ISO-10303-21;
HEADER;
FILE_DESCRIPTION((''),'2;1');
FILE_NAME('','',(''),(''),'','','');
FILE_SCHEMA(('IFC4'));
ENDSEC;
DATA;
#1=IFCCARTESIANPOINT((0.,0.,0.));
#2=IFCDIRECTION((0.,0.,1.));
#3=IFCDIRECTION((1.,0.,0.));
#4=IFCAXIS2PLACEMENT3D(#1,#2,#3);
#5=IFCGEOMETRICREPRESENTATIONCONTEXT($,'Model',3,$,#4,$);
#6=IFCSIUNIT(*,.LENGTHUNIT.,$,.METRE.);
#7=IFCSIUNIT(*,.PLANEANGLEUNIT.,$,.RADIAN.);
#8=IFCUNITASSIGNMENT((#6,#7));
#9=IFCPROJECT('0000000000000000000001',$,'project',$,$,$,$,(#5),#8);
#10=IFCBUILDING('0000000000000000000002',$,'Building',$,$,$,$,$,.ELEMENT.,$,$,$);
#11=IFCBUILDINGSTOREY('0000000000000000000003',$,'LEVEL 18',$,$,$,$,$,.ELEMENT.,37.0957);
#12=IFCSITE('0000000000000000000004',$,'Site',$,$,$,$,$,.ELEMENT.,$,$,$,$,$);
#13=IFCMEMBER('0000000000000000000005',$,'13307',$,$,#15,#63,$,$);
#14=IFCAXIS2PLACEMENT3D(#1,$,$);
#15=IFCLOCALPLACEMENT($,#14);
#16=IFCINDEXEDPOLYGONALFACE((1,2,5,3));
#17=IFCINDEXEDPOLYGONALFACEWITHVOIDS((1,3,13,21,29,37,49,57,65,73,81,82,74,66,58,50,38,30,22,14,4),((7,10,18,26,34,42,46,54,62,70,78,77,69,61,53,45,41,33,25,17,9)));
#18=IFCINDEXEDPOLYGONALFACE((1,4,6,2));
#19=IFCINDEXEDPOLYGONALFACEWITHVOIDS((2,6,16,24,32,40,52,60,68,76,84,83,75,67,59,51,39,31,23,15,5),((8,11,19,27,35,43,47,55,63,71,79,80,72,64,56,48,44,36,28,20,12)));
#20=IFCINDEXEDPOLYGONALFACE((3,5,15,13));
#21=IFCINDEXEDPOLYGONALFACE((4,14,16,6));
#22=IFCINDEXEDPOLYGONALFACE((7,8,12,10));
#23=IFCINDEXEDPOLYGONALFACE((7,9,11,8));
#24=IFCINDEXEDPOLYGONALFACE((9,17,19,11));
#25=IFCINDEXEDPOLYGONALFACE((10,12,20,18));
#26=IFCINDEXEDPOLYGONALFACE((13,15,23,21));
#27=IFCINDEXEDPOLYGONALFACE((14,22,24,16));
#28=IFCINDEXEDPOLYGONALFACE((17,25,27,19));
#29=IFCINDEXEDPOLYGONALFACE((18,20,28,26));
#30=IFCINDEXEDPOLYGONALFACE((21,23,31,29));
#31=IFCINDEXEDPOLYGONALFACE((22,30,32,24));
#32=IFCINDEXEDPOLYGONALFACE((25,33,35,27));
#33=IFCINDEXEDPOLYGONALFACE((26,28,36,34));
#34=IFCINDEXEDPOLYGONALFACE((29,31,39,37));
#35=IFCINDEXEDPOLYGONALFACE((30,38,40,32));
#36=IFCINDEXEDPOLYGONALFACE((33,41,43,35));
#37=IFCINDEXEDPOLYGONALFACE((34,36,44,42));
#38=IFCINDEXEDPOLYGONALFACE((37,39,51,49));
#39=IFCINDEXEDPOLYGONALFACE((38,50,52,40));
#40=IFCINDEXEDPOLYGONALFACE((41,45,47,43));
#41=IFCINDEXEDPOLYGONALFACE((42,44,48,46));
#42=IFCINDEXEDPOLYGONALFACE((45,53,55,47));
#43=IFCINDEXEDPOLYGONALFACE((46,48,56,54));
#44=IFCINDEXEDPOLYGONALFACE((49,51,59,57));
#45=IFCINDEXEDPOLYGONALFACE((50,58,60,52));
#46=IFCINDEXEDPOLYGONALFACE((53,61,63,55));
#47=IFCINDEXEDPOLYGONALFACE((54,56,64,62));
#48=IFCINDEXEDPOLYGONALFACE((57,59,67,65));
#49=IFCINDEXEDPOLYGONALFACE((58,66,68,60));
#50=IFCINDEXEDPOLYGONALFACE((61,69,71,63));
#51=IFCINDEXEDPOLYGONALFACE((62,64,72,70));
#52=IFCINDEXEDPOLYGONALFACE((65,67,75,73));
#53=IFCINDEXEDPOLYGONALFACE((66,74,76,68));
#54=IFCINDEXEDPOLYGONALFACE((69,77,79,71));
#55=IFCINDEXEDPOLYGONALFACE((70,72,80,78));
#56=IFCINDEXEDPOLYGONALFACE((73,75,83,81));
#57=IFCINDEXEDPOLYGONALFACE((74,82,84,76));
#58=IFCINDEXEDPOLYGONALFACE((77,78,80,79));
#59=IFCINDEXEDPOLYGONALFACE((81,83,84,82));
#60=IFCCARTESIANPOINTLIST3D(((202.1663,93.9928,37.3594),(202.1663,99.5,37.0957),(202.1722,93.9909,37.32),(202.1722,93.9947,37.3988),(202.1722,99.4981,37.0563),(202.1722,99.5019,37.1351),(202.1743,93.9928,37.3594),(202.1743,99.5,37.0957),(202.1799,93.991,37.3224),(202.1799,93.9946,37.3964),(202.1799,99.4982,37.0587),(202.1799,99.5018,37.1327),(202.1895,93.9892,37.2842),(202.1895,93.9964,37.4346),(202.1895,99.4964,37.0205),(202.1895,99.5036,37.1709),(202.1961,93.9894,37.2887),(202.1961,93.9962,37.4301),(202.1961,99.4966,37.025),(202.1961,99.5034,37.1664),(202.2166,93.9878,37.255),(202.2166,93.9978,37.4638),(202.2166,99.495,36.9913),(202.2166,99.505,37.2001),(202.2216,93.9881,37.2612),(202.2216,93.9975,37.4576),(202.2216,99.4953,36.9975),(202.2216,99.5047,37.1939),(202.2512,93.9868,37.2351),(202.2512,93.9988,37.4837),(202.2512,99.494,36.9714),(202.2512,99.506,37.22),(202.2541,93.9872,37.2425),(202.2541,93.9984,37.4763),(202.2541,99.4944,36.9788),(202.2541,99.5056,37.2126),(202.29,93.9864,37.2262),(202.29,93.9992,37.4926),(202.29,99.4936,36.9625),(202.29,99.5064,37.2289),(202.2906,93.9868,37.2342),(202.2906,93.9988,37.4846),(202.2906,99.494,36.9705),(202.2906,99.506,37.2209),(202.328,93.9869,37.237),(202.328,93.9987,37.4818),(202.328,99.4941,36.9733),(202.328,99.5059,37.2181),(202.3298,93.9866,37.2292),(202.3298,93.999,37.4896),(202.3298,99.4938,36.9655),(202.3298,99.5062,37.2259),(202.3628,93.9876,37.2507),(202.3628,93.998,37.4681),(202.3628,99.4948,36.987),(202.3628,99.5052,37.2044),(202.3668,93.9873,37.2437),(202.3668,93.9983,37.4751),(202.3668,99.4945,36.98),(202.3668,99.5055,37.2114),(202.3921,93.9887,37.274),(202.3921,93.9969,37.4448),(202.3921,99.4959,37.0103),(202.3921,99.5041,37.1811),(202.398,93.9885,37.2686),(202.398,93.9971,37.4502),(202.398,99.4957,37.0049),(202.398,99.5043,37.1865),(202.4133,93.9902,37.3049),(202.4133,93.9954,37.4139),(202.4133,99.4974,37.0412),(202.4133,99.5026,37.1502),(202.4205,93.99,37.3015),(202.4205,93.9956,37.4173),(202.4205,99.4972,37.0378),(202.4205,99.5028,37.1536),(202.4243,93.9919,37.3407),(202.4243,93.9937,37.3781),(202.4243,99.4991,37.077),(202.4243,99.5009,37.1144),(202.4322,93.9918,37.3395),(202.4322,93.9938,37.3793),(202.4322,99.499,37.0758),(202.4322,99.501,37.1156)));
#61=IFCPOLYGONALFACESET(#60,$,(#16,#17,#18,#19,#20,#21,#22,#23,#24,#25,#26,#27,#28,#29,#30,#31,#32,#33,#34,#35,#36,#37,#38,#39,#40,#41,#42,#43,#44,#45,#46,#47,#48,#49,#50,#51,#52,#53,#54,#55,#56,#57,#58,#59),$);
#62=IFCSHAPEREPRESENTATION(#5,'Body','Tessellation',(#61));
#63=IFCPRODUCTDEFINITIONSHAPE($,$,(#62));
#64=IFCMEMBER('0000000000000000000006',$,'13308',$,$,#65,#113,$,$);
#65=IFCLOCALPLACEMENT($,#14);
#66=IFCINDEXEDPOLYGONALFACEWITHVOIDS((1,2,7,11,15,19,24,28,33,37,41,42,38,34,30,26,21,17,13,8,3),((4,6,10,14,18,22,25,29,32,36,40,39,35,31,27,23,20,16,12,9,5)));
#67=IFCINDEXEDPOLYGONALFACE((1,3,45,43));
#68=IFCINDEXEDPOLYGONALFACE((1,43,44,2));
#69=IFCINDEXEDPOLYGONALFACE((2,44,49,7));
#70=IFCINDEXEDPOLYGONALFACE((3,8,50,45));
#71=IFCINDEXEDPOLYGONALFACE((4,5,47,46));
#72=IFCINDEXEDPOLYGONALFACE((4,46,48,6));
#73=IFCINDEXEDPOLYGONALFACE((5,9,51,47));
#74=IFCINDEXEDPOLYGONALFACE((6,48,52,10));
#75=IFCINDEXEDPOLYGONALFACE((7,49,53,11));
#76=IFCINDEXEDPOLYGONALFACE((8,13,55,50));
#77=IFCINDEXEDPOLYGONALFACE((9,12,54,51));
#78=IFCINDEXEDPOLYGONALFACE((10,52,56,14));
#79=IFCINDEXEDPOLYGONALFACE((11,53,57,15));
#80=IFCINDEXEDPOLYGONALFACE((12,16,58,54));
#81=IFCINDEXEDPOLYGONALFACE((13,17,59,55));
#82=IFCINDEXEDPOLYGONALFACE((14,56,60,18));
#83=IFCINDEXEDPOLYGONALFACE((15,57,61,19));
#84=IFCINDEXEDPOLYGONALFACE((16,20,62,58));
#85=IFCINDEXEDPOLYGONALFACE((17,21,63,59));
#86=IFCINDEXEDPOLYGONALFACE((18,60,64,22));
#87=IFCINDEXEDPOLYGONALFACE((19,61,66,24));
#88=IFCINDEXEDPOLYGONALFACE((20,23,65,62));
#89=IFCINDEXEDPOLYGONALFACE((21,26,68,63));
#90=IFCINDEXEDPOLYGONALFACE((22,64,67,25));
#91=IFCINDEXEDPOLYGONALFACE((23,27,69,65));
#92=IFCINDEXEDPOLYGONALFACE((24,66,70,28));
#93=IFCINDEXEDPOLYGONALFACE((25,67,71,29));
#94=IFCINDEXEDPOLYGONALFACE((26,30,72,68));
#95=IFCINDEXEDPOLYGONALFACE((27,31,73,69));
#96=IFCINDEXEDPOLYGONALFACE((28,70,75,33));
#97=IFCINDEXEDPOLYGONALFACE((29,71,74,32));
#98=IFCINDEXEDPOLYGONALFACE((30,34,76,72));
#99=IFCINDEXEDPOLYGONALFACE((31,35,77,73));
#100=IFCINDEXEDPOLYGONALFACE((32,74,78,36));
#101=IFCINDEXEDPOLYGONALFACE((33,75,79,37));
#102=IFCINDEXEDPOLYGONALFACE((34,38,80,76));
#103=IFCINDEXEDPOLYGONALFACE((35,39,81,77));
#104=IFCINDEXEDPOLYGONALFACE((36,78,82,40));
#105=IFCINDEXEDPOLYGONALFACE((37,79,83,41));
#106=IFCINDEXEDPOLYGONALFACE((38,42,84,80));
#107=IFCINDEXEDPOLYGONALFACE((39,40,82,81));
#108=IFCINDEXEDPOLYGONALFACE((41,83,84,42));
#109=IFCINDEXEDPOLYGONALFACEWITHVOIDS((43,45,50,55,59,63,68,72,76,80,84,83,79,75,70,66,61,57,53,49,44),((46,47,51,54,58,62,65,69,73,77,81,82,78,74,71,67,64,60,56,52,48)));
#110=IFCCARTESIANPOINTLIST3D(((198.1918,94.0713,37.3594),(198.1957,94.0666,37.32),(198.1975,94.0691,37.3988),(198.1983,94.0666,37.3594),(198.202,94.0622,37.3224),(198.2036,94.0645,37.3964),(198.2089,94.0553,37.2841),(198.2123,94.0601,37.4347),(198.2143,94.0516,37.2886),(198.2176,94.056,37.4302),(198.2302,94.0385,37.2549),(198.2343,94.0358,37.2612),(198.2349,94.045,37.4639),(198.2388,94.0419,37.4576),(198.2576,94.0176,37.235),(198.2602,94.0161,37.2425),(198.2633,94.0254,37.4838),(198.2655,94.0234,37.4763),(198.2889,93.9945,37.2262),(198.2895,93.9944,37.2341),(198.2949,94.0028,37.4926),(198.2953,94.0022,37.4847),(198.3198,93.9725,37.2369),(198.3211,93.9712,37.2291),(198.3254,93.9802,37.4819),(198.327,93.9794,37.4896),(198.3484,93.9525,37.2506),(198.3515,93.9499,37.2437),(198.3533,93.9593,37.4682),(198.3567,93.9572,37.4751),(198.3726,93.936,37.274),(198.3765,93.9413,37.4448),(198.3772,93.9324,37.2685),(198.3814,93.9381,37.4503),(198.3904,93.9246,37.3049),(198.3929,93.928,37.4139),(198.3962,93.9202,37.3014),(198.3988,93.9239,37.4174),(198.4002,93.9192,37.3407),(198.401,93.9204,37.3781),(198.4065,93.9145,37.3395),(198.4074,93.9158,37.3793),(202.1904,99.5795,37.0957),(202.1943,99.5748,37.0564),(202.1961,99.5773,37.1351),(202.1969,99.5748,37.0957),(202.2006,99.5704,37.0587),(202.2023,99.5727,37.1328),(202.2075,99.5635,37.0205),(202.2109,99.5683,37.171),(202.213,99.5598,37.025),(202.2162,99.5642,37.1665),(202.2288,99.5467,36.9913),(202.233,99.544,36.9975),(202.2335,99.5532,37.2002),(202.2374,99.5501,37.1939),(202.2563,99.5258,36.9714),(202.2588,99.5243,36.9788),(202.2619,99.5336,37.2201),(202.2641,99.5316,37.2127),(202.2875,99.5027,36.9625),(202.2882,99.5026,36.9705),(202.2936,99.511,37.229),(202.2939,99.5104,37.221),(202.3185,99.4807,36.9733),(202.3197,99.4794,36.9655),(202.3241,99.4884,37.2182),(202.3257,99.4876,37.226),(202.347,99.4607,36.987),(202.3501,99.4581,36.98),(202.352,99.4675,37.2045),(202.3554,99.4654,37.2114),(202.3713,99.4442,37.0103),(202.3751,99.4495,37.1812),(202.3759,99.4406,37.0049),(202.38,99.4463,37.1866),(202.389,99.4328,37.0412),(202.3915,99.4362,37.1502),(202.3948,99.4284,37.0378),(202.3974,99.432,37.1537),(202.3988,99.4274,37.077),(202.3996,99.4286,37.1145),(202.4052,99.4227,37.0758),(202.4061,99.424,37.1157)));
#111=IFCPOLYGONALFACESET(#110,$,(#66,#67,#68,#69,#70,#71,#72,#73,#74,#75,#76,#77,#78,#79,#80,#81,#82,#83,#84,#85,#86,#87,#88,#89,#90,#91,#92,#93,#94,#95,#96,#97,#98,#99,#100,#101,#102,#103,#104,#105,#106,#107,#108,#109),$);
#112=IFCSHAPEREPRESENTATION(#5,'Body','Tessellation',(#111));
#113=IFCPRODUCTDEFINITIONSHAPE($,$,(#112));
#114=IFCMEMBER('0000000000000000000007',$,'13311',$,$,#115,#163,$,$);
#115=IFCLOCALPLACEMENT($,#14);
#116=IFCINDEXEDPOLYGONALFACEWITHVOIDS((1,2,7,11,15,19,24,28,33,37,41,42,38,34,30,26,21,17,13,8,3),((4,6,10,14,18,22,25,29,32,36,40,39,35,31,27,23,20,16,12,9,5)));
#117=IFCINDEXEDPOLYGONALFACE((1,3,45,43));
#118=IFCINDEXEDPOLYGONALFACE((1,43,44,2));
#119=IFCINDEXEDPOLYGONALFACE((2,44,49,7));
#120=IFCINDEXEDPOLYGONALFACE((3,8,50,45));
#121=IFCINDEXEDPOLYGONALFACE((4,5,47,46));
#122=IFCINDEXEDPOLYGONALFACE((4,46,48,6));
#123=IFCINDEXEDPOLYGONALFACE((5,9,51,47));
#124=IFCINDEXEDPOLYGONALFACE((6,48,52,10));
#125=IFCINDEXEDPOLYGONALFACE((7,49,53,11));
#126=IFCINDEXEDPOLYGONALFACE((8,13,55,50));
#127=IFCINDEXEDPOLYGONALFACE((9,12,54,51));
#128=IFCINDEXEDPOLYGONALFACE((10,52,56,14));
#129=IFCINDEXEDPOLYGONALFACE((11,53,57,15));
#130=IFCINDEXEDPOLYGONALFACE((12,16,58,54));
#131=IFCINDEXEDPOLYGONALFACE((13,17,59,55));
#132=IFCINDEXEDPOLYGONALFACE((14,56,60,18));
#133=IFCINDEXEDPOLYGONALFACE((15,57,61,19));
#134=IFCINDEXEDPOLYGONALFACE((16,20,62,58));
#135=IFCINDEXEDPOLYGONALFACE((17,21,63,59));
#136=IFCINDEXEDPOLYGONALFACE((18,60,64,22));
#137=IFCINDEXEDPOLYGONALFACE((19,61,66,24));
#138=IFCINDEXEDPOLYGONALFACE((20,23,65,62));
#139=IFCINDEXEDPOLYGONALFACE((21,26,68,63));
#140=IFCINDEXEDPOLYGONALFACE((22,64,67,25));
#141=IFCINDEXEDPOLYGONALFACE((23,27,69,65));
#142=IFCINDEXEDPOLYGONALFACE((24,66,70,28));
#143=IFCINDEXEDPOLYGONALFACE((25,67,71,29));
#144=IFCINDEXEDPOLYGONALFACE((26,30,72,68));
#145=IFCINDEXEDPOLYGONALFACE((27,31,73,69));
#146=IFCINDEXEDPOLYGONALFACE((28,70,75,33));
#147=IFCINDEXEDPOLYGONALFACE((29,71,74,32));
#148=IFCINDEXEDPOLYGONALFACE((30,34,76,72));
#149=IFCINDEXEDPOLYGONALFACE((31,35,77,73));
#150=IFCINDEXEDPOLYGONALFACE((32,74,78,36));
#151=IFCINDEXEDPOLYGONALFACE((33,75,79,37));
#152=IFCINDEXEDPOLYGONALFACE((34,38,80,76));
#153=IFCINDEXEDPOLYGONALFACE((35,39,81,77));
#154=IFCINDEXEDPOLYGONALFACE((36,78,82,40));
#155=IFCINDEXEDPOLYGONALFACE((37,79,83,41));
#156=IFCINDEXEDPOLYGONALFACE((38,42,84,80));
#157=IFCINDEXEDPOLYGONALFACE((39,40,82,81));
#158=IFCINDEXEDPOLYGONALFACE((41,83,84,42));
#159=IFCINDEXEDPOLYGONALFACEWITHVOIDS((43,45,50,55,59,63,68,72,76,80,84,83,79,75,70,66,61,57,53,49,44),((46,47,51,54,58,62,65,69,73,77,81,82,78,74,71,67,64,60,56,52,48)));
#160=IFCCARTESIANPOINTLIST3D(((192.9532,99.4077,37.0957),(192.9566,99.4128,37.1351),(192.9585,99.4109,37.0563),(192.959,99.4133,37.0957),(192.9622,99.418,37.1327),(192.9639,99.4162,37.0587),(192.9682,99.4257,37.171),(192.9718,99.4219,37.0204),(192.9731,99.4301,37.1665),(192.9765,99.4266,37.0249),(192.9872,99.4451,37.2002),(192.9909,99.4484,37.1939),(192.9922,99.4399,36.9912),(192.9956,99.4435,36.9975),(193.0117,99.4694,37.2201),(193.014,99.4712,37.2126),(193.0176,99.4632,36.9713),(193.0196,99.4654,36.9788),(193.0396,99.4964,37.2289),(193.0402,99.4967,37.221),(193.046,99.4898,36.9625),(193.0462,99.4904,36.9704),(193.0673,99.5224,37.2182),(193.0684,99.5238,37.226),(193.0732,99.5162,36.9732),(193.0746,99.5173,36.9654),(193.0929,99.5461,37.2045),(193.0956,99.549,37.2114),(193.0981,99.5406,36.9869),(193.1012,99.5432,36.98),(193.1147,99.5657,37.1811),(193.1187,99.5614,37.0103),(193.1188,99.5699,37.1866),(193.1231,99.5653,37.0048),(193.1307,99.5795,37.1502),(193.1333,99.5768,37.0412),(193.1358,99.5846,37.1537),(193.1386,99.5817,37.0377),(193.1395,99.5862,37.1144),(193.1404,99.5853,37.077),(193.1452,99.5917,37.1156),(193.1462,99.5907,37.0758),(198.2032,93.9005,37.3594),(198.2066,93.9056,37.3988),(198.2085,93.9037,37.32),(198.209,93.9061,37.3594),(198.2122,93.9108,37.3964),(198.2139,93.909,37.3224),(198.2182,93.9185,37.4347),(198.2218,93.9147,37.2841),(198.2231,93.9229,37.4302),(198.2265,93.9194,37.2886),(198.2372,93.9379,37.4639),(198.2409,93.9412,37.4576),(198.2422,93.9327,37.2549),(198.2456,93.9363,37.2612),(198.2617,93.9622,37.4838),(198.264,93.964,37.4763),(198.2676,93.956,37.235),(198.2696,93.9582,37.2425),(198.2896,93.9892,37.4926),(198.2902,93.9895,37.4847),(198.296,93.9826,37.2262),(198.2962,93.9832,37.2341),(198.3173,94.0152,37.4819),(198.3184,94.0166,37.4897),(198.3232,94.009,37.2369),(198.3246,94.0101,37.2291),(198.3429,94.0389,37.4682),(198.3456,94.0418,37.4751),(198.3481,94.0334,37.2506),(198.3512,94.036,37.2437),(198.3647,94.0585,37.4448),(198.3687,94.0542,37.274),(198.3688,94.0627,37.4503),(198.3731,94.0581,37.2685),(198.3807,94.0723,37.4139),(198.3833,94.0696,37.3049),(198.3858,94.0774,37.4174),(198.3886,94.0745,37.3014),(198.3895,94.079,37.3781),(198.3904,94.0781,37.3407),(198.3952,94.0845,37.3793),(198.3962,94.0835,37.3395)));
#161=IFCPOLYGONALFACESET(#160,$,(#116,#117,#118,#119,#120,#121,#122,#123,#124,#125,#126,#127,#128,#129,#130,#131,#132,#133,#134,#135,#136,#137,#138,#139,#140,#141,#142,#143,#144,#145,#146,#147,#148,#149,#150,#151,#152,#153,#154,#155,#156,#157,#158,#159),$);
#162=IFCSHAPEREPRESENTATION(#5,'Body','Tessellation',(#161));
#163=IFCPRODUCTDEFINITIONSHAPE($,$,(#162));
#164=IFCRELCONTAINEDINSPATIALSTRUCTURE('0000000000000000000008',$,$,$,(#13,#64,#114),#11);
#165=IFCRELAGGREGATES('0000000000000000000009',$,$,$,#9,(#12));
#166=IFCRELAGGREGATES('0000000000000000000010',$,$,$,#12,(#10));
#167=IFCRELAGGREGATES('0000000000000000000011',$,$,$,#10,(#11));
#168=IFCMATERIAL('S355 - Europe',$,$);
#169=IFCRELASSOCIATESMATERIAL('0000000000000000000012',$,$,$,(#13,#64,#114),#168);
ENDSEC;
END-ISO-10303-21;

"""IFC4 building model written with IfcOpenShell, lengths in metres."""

from ifc_helpers import new_model, si_unit, frame, origin_with_axes, origin_2d_with_axis, place, context, project, spatial, hollow_circle, extrude, material, material_profile, profile_set, profile_usage, element, save


model = new_model("IFC4")

# Units and contexts
model_context = context("Model", 3, world=origin_with_axes())
ifc_project = project(units=[si_unit("LENGTHUNIT", "METRE"), si_unit("PLANEANGLEUNIT", "RADIAN")], contexts=[model_context])

# Site, building, storey
site = spatial("IfcSite", under=ifc_project, Name="Site", CompositionType="ELEMENT")
building = spatial("IfcBuilding", under=site, Name="Building", CompositionType="ELEMENT")
storey = spatial("IfcBuildingStorey", under=building, Name="LEVEL 18", CompositionType="ELEMENT", Elevation=37.0957)

# Shared definitions
ifc_material = material(Name="S355 - Europe")

# Members
ifc_material_profile_1 = material_profile(ifc_material, hollow_circle(Radius=0.1337, WallThickness=0.008, at=origin_2d_with_axis()))
ifc_profile_set_1 = profile_set([ifc_material_profile_1])
ifc_profile_usage_1 = profile_usage(ifc_profile_set_1, cardinal=10)
member_1_placement = place(None, frame((202.3, 93.9928, 37.3594), z_axis=(0.0, 0.998856, -0.047828), x_axis=(-1.0, 0.0, 0.0)))
element("IfcMember", 1, at=member_1_placement, inside=storey, material=ifc_profile_usage_1, Name="13307", context=model_context, shape_type="SweptSolid", body=[
    extrude(hollow_circle(Radius=0.1337, WallThickness=0.008, at=origin_2d_with_axis()), origin_with_axes(), (0.0, 0.0, 1.0), 5.5135),
])
ifc_material_profile_2 = material_profile(ifc_material, hollow_circle(Radius=0.1337, WallThickness=0.008, at=origin_2d_with_axis()))
ifc_profile_set_2 = profile_set([ifc_material_profile_2])
ifc_profile_usage_2 = profile_usage(ifc_profile_set_2, cardinal=10)
member_2_placement = place(None, frame((198.3, 93.9928, 37.3594), z_axis=(0.587027, 0.808642, -0.038707), x_axis=(-0.808921, 0.587918, 0.0)))
element("IfcMember", 2, at=member_2_placement, inside=storey, material=ifc_profile_usage_2, Name="13308", context=model_context, shape_type="SweptSolid", body=[
    extrude(hollow_circle(Radius=0.1337, WallThickness=0.008, at=origin_2d_with_axis()), origin_with_axes(), (0.0, 0.0, 1.0), 6.8117),
])
ifc_material_profile_3 = material_profile(ifc_material, hollow_circle(Radius=0.1337, WallThickness=0.008, at=origin_2d_with_axis()))
ifc_profile_set_3 = profile_set([ifc_material_profile_3])
ifc_profile_usage_3 = profile_usage(ifc_profile_set_3, cardinal=10)
member_3_placement = place(None, frame((198.3, 93.9928, 37.3594), z_axis=(-0.689589, 0.723372, -0.034637), x_axis=(-0.723807, -0.690003, 0.0)))
element("IfcMember", 3, at=member_3_placement, inside=storey, material=ifc_profile_usage_3, Name="13311", context=model_context, shape_type="SweptSolid", body=[
    extrude(hollow_circle(Radius=0.1337, WallThickness=0.008, at=origin_2d_with_axis()), origin_with_axes(), (0.0, 0.0, 1.0), 7.6132),
])

save(model, "model.ifc")
